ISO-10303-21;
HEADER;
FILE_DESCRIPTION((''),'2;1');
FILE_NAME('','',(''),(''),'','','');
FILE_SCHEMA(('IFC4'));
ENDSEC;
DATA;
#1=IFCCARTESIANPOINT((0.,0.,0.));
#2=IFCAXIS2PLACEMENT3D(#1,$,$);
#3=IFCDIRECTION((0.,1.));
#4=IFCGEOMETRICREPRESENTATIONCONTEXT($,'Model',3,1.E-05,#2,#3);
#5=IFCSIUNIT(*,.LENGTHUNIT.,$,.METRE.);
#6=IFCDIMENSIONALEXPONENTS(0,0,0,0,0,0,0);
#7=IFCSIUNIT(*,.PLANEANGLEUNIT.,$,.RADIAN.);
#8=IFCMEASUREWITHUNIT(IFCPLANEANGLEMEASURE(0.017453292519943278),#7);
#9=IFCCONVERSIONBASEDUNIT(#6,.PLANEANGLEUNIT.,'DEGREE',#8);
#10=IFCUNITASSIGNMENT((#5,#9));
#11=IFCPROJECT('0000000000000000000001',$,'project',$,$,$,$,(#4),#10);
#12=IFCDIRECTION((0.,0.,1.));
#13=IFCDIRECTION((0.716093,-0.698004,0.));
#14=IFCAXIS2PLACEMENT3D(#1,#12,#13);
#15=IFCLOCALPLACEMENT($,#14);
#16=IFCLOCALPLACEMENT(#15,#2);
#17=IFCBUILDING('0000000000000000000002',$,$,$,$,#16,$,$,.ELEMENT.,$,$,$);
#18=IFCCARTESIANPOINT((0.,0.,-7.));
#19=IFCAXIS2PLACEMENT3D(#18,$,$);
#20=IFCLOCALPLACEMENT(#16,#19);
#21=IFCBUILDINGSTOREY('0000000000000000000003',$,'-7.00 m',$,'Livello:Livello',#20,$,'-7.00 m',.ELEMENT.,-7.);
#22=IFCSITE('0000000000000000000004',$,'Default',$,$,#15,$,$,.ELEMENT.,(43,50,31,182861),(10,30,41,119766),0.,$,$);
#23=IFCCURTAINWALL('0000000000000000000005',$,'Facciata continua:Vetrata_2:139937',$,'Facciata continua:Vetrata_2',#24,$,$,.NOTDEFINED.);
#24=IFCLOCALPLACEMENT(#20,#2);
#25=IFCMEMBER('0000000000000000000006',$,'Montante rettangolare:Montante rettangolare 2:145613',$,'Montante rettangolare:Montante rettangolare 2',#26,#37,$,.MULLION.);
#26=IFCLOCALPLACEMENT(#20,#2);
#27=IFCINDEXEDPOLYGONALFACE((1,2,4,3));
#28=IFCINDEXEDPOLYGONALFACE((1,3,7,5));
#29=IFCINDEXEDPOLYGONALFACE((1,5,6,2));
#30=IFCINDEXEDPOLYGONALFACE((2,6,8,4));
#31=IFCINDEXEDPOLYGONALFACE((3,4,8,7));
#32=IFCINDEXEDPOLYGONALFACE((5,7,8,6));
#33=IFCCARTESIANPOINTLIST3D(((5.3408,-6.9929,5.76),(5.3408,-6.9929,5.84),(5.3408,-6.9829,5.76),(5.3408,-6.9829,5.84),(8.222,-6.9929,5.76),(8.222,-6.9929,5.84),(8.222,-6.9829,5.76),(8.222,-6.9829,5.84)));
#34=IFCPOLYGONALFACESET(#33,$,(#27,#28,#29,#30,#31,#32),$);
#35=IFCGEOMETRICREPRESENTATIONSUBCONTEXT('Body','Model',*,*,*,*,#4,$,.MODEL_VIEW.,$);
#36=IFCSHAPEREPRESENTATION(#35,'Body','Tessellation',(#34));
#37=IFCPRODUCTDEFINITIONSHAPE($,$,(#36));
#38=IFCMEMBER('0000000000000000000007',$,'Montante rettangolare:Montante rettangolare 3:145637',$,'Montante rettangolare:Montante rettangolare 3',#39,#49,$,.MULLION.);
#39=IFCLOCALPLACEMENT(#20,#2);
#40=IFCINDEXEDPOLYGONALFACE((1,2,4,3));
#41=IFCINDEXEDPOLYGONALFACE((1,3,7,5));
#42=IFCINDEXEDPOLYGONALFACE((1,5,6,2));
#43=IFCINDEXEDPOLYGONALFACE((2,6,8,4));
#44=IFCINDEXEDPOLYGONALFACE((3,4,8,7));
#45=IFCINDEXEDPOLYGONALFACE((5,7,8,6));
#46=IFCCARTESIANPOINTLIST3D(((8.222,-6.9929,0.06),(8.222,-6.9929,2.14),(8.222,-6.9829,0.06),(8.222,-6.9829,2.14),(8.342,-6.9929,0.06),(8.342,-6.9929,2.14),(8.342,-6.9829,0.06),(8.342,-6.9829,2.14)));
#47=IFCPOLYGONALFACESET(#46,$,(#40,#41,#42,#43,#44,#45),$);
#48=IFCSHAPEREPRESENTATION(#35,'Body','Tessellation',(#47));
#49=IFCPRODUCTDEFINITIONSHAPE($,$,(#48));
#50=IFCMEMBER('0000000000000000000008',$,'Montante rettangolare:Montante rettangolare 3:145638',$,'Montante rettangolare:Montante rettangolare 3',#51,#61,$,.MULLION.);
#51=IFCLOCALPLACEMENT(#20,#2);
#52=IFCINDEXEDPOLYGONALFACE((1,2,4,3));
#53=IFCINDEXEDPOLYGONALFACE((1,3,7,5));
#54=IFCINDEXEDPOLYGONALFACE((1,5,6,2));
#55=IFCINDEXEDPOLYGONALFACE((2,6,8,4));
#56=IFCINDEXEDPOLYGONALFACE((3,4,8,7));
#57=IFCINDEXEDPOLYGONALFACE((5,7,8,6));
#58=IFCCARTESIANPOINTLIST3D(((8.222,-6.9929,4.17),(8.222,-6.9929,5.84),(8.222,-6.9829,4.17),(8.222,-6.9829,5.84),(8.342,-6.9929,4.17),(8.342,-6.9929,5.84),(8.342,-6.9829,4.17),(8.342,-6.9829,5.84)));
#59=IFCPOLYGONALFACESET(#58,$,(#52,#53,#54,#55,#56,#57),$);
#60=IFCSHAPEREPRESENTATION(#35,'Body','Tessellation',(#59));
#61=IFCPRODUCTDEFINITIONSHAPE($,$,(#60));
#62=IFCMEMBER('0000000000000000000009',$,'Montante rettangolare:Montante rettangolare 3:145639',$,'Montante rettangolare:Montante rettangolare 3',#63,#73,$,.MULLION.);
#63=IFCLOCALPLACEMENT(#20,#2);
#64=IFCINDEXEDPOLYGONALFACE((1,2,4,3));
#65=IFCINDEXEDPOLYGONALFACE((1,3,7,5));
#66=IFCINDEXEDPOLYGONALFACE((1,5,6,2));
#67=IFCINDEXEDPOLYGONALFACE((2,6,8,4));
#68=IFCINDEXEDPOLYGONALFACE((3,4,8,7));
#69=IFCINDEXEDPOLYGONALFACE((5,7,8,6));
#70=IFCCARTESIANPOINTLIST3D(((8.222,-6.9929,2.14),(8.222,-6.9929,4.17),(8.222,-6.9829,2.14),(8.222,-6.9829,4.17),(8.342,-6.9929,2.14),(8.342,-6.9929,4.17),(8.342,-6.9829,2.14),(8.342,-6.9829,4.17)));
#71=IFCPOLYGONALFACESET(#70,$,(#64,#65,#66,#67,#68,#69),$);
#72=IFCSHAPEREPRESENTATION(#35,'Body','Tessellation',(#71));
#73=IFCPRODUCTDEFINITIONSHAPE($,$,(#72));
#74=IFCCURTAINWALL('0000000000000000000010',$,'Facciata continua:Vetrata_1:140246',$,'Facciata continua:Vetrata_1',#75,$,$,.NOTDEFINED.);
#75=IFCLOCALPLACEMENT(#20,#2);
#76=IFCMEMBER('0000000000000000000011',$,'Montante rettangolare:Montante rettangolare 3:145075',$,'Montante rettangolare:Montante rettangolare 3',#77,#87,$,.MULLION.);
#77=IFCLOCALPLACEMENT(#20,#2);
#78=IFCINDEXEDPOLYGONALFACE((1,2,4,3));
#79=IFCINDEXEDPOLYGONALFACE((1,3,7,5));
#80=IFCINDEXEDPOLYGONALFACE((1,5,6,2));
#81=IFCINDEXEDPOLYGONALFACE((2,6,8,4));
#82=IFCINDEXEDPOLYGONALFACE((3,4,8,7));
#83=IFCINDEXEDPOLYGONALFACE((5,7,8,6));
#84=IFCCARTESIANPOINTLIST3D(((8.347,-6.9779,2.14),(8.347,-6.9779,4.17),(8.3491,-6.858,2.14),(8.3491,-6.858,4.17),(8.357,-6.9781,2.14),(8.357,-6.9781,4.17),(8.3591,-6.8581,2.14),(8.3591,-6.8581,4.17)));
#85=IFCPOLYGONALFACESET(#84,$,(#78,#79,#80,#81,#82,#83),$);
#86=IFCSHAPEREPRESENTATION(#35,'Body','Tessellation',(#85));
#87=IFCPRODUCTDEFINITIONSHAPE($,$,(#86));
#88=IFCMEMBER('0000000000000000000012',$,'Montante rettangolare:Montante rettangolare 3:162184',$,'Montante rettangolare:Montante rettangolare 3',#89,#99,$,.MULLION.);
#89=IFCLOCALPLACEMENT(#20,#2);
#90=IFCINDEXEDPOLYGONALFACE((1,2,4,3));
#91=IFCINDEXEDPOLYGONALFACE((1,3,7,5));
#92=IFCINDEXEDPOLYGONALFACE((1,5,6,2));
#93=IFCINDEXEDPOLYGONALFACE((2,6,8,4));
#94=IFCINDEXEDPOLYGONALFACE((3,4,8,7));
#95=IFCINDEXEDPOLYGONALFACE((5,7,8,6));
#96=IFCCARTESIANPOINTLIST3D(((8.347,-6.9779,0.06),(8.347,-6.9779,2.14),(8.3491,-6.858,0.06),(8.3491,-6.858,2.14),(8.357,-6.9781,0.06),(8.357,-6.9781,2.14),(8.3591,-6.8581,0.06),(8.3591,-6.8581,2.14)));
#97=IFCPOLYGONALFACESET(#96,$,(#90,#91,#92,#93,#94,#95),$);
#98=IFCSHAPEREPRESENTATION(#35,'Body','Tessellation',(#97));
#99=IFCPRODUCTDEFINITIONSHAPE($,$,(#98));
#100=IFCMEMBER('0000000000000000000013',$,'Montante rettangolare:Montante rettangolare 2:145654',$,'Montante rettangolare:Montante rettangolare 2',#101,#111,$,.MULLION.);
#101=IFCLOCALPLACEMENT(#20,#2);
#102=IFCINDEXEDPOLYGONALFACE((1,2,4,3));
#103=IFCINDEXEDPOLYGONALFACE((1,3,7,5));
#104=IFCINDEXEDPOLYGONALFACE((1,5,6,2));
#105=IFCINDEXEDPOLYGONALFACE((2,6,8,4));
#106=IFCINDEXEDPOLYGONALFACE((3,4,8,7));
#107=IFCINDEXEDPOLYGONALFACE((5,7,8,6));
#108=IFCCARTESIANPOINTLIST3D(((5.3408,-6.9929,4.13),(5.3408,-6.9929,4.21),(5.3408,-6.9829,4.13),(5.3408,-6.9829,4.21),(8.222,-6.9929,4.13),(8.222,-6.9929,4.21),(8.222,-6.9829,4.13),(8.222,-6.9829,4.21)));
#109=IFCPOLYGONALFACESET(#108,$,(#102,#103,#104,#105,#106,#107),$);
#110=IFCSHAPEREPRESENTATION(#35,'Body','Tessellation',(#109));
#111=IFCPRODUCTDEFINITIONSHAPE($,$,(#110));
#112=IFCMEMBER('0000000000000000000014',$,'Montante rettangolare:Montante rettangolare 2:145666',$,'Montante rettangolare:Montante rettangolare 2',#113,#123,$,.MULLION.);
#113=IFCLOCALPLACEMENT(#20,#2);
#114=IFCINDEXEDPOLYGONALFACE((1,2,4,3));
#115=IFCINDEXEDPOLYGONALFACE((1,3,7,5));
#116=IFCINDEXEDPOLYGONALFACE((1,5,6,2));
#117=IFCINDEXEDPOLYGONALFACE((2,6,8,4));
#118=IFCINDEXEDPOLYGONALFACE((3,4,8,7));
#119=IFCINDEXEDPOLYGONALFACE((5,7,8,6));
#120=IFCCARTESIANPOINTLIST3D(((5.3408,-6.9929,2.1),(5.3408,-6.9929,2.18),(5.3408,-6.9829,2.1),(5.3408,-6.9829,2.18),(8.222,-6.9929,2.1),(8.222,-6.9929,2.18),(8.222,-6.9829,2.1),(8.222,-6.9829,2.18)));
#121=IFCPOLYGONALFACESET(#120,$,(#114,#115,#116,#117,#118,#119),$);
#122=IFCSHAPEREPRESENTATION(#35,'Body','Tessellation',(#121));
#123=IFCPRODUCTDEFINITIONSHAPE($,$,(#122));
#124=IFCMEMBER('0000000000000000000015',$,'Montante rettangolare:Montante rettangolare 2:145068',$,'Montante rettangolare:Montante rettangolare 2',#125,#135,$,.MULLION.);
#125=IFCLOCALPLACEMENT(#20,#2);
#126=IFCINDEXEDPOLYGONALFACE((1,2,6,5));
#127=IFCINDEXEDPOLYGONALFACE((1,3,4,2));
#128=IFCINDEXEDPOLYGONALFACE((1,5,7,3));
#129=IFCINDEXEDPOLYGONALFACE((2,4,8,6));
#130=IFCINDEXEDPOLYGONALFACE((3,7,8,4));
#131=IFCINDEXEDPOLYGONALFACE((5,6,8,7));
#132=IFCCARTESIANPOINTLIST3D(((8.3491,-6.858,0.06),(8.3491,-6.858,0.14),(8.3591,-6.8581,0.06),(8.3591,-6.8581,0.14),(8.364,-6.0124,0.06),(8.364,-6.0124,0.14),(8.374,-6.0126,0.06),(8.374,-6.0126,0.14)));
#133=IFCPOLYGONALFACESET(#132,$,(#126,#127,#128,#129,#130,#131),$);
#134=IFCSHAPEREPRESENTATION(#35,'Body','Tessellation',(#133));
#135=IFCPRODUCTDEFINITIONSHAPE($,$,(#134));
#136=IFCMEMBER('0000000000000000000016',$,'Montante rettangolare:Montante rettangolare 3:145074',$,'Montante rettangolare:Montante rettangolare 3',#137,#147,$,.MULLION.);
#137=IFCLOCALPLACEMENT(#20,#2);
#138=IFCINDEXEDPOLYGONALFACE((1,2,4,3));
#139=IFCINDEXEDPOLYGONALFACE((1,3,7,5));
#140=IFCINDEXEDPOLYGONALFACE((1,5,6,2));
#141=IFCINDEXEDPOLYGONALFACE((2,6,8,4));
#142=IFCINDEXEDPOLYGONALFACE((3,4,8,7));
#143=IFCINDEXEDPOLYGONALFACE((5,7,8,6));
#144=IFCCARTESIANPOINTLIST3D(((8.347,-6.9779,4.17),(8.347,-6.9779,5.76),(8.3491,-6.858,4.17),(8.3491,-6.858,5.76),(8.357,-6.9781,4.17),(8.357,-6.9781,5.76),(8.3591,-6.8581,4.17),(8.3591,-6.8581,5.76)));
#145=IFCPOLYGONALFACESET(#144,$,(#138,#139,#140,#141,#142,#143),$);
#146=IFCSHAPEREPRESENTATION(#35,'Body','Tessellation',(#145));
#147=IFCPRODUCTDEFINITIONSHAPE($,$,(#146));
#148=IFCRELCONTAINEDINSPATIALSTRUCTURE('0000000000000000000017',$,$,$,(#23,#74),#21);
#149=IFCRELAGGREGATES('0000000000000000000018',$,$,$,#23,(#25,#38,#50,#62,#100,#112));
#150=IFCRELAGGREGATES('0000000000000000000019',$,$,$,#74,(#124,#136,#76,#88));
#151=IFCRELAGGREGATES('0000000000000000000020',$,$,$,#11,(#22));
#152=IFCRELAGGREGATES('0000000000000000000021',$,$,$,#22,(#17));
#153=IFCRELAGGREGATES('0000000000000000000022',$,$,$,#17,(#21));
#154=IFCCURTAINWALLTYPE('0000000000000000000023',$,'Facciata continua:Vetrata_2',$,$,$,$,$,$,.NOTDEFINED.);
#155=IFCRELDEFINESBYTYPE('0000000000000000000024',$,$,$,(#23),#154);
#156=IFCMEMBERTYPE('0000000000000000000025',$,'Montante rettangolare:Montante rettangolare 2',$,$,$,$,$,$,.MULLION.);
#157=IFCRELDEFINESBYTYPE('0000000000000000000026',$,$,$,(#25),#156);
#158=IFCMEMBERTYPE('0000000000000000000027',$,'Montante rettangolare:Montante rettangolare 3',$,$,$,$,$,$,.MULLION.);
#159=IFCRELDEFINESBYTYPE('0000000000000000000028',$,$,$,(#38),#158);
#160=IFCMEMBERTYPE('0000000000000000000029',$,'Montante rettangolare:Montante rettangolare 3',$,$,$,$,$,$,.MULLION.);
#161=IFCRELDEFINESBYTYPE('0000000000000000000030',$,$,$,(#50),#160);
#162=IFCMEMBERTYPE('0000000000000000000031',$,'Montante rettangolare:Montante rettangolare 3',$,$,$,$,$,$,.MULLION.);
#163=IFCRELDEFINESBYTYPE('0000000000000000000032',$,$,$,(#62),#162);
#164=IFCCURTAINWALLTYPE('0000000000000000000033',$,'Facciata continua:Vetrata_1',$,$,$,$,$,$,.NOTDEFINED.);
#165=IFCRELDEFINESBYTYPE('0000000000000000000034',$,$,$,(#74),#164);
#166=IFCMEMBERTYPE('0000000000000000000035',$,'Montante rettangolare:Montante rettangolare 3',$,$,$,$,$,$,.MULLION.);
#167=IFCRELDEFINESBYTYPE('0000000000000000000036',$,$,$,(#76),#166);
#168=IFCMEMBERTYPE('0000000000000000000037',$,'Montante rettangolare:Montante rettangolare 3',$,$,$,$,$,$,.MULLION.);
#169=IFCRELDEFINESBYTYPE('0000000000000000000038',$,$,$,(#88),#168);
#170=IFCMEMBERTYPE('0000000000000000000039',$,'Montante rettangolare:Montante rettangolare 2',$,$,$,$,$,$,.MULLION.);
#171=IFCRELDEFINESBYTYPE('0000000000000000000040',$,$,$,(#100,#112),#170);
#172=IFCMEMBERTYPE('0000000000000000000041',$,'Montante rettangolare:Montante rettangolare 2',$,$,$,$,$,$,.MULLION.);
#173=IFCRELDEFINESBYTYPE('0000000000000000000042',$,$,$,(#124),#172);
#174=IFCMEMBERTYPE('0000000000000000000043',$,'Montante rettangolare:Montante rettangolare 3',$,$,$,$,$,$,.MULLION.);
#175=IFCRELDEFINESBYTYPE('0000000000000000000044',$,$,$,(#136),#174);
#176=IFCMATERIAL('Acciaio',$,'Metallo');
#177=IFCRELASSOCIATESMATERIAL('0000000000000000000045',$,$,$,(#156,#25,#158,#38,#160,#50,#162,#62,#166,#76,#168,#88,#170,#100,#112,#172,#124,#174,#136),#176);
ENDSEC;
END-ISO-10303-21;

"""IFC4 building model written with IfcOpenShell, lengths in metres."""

from ifc_helpers import new_model, entity, si_unit, converted_unit, direction, frame, origin, place, context, subcontext, project, spatial, indexed_curve, outline, extrude, source, transform, mapped, material, type_object, type_shapes, element, aggregate, save


model = new_model("IFC4")

# Units and contexts
model_context = context("Model", 3, precision=1e-05, world=origin(), true_north=direction((0.0, 1.0)))
body_context = subcontext(model_context, "Body", "Model", "MODEL_VIEW")
ifc_project = project(units=[si_unit("LENGTHUNIT", "METRE"), converted_unit("PLANEANGLEUNIT", "DEGREE", entity("IfcPlaneAngleMeasure", 0.017453292519943278), si_unit("PLANEANGLEUNIT", "RADIAN"), dimensions=[0, 0, 0, 0, 0, 0, 0])], contexts=[model_context])

# Site, building, storey
site_placement = place(None, frame((0.0, 0.0, 0.0), z_axis=(0.0, 0.0, 1.0), x_axis=(0.716093, -0.698004, 0.0)))
site = spatial("IfcSite", under=ifc_project, at=site_placement, Name="Default", CompositionType="ELEMENT", RefLatitude=(43, 50, 31, 182861), RefLongitude=(10, 30, 41, 119766), RefElevation=0.0)
building_placement = place(site_placement, origin())
building = spatial("IfcBuilding", under=site, at=building_placement, CompositionType="ELEMENT")
storey_placement = place(building_placement, frame((0.0, 0.0, -7.0)))
storey = spatial("IfcBuildingStorey", under=building, at=storey_placement, Name="-7.00 m", ObjectType="Livello:Livello", LongName="-7.00 m", CompositionType="ELEMENT", Elevation=-7.0)

# Curtain walls, members
curtain_wall_type_1 = type_object("IfcCurtainWallType", Name="Facciata continua:Vetrata_2", PredefinedType="NOTDEFINED")
curtain_wall_1_placement = place(storey_placement, frame((0.0, 0.0, 7.0)))
curtain_wall_1 = element("IfcCurtainWall", 1, at=curtain_wall_1_placement, inside=storey, type_object=curtain_wall_type_1, Name="Facciata continua:Vetrata_2:139937", ObjectType="Facciata continua:Vetrata_2", PredefinedType="NOTDEFINED")
ifc_material_1 = material(Name="Acciaio", Category="Metallo")
member_type_1 = type_object("IfcMemberType", Name="Montante rettangolare:Montante rettangolare 2", PredefinedType="MULLION", material=ifc_material_1)
shared_shape_1 = source(origin(), body_context, "Body", "SweptSolid", [
    extrude(outline(indexed_curve([(-0.04, -0.005), (0.04, -0.005), (0.04, 0.005), (-0.04, 0.005), (-0.04, -0.005)], self_intersect=False)), frame((-0.04, 0.01, -2.8812), z_axis=(0.0, 0.0, 1.0), x_axis=(-1.0, 0.0, 0.0)), (0.0, 0.0, 1.0), 2.8812),
])
type_shapes(member_type_1, [shared_shape_1])
member_1_placement = place(curtain_wall_1_placement, frame((8.222, -6.9779, -1.16), z_axis=(1.0, 0.0, 0.0), x_axis=(0.0, 0.0, 1.0)))
member_1 = element("IfcMember", 2, at=member_1_placement, type_object=member_type_1, material=ifc_material_1, Name="Montante rettangolare:Montante rettangolare 2:145613", ObjectType="Montante rettangolare:Montante rettangolare 2", PredefinedType="MULLION", context=body_context, shape_type="MappedRepresentation", body=[
    mapped(shared_shape_1, transform((0.0, 0.0, 0.0), scale=1.0)),
])
member_type_2 = type_object("IfcMemberType", Name="Montante rettangolare:Montante rettangolare 3", PredefinedType="MULLION", material=ifc_material_1)
shared_shape_2 = source(origin(), body_context, "Body", "SweptSolid", [
    extrude(outline(indexed_curve([(-0.06, -0.005), (0.06, -0.005), (0.06, 0.005), (-0.06, 0.005), (-0.06, -0.005)], self_intersect=False)), frame((-0.06, 0.01, -2.08), z_axis=(0.0, 0.0, 1.0), x_axis=(-1.0, 0.0, 0.0)), (0.0, 0.0, 1.0), 2.08),
])
type_shapes(member_type_2, [shared_shape_2])
member_2_placement = place(curtain_wall_1_placement, frame((8.342, -6.9779, -6.94), z_axis=(0.0, 0.0, -1.0), x_axis=(1.0, 0.0, 0.0)))
member_2 = element("IfcMember", 3, at=member_2_placement, type_object=member_type_2, material=ifc_material_1, Name="Montante rettangolare:Montante rettangolare 3:145637", ObjectType="Montante rettangolare:Montante rettangolare 3", PredefinedType="MULLION", context=body_context, shape_type="MappedRepresentation", body=[
    mapped(shared_shape_2, transform((0.0, 0.0, 0.0), scale=1.0)),
])
member_type_3 = type_object("IfcMemberType", Name="Montante rettangolare:Montante rettangolare 3", PredefinedType="MULLION", material=ifc_material_1)
shared_shape_3 = source(origin(), body_context, "Body", "SweptSolid", [
    extrude(outline(indexed_curve([(-0.06, -0.005), (0.06, -0.005), (0.06, 0.005), (-0.06, 0.005), (-0.06, -0.005)], self_intersect=False)), frame((-0.06, 0.01, -1.67), z_axis=(0.0, 0.0, 1.0), x_axis=(-1.0, 0.0, 0.0)), (0.0, 0.0, 1.0), 1.67),
])
type_shapes(member_type_3, [shared_shape_3])
member_3_placement = place(curtain_wall_1_placement, frame((8.342, -6.9779, -2.83), z_axis=(0.0, 0.0, -1.0), x_axis=(1.0, 0.0, 0.0)))
member_3 = element("IfcMember", 4, at=member_3_placement, type_object=member_type_3, material=ifc_material_1, Name="Montante rettangolare:Montante rettangolare 3:145638", ObjectType="Montante rettangolare:Montante rettangolare 3", PredefinedType="MULLION", context=body_context, shape_type="MappedRepresentation", body=[
    mapped(shared_shape_3, transform((0.0, 0.0, 0.0), scale=1.0)),
])
member_type_4 = type_object("IfcMemberType", Name="Montante rettangolare:Montante rettangolare 3", PredefinedType="MULLION", material=ifc_material_1)
shared_shape_4 = source(origin(), body_context, "Body", "SweptSolid", [
    extrude(outline(indexed_curve([(-0.06, -0.005), (0.06, -0.005), (0.06, 0.005), (-0.06, 0.005), (-0.06, -0.005)], self_intersect=False)), frame((-0.06, 0.01, -2.03), z_axis=(0.0, 0.0, 1.0), x_axis=(-1.0, 0.0, 0.0)), (0.0, 0.0, 1.0), 2.03),
])
type_shapes(member_type_4, [shared_shape_4])
member_4_placement = place(curtain_wall_1_placement, frame((8.342, -6.9779, -4.86), z_axis=(0.0, 0.0, -1.0), x_axis=(1.0, 0.0, 0.0)))
member_4 = element("IfcMember", 5, at=member_4_placement, type_object=member_type_4, material=ifc_material_1, Name="Montante rettangolare:Montante rettangolare 3:145639", ObjectType="Montante rettangolare:Montante rettangolare 3", PredefinedType="MULLION", context=body_context, shape_type="MappedRepresentation", body=[
    mapped(shared_shape_4, transform((0.0, 0.0, 0.0), scale=1.0)),
])
curtain_wall_type_2 = type_object("IfcCurtainWallType", Name="Facciata continua:Vetrata_1", PredefinedType="NOTDEFINED")
curtain_wall_2_placement = place(storey_placement, frame((0.0, 0.0, 7.0)))
curtain_wall_2 = element("IfcCurtainWall", 6, at=curtain_wall_2_placement, inside=storey, type_object=curtain_wall_type_2, Name="Facciata continua:Vetrata_1:140246", ObjectType="Facciata continua:Vetrata_1", PredefinedType="NOTDEFINED")
member_type_5 = type_object("IfcMemberType", Name="Montante rettangolare:Montante rettangolare 3", PredefinedType="MULLION", material=ifc_material_1)
shared_shape_5 = source(origin(), body_context, "Body", "SweptSolid", [
    extrude(outline(indexed_curve([(-0.06, -0.005), (0.06, -0.005), (0.06, 0.005), (-0.06, 0.005), (-0.06, -0.005)], self_intersect=False)), frame((-0.06, 0.01, -2.03), z_axis=(0.0, 0.0, 1.0), x_axis=(-1.0, 0.0, 0.0)), (0.0, 0.0, 1.0), 2.03),
])
type_shapes(member_type_5, [shared_shape_5])
member_5_placement = place(curtain_wall_2_placement, frame((8.342, -6.9779, -2.83), z_axis=(0.0, 0.0, 1.0), x_axis=(-0.017636, -0.999844, 0.0)))
member_5 = element("IfcMember", 7, at=member_5_placement, type_object=member_type_5, material=ifc_material_1, Name="Montante rettangolare:Montante rettangolare 3:145075", ObjectType="Montante rettangolare:Montante rettangolare 3", PredefinedType="MULLION", context=body_context, shape_type="MappedRepresentation", body=[
    mapped(shared_shape_5, transform((0.0, 0.0, 0.0), scale=1.0)),
])
member_type_6 = type_object("IfcMemberType", Name="Montante rettangolare:Montante rettangolare 3", PredefinedType="MULLION", material=ifc_material_1)
shared_shape_6 = source(origin(), body_context, "Body", "SweptSolid", [
    extrude(outline(indexed_curve([(-0.06, -0.005), (0.06, -0.005), (0.06, 0.005), (-0.06, 0.005), (-0.06, -0.005)], self_intersect=False)), frame((-0.06, 0.01, -2.08), z_axis=(0.0, 0.0, 1.0), x_axis=(-1.0, 0.0, 0.0)), (0.0, 0.0, 1.0), 2.08),
])
type_shapes(member_type_6, [shared_shape_6])
member_6_placement = place(curtain_wall_2_placement, frame((8.342, -6.9779, -4.86), z_axis=(0.0, 0.0, 1.0), x_axis=(-0.017636, -0.999844, 0.0)))
member_6 = element("IfcMember", 8, at=member_6_placement, type_object=member_type_6, material=ifc_material_1, Name="Montante rettangolare:Montante rettangolare 3:162184", ObjectType="Montante rettangolare:Montante rettangolare 3", PredefinedType="MULLION", context=body_context, shape_type="MappedRepresentation", body=[
    mapped(shared_shape_6, transform((0.0, 0.0, 0.0), scale=1.0)),
])

# Members
member_type_7 = type_object("IfcMemberType", Name="Montante rettangolare:Montante rettangolare 2", PredefinedType="MULLION", material=ifc_material_1)
shared_shape_7 = source(origin(), body_context, "Body", "SweptSolid", [
    extrude(outline(indexed_curve([(-0.04, -0.005), (0.04, -0.005), (0.04, 0.005), (-0.04, 0.005), (-0.04, -0.005)], self_intersect=False)), frame((0.0, 0.01, -2.8812), z_axis=(0.0, 0.0, 1.0), x_axis=(-1.0, 0.0, 0.0)), (0.0, 0.0, 1.0), 2.8812),
])
type_shapes(member_type_7, [shared_shape_7])
member_7_placement = place(curtain_wall_1_placement, frame((8.222, -6.9779, -2.83), z_axis=(1.0, 0.0, 0.0), x_axis=(0.0, 0.0, 1.0)))
member_7 = element("IfcMember", 9, at=member_7_placement, type_object=member_type_7, material=ifc_material_1, Name="Montante rettangolare:Montante rettangolare 2:145654", ObjectType="Montante rettangolare:Montante rettangolare 2", PredefinedType="MULLION", context=body_context, shape_type="MappedRepresentation", body=[
    mapped(shared_shape_7, transform((0.0, 0.0, 0.0), scale=1.0)),
])
member_8_placement = place(curtain_wall_1_placement, frame((8.222, -6.9779, -4.86), z_axis=(1.0, 0.0, 0.0), x_axis=(0.0, 0.0, 1.0)))
member_8 = element("IfcMember", 10, at=member_8_placement, type_object=member_type_7, material=ifc_material_1, Name="Montante rettangolare:Montante rettangolare 2:145666", ObjectType="Montante rettangolare:Montante rettangolare 2", PredefinedType="MULLION", context=body_context, shape_type="MappedRepresentation", body=[
    mapped(shared_shape_7, transform((0.0, 0.0, 0.0), scale=1.0)),
])
member_type_8 = type_object("IfcMemberType", Name="Montante rettangolare:Montante rettangolare 2", PredefinedType="MULLION", material=ifc_material_1)
shared_shape_8 = source(origin(), body_context, "Body", "SweptSolid", [
    extrude(outline(indexed_curve([(-0.04, -0.005), (0.04, -0.005), (0.04, 0.005), (-0.04, 0.005), (-0.04, -0.005)], self_intersect=False)), frame((-0.04, 0.01, -0.8457), z_axis=(0.0, 0.0, 1.0), x_axis=(-1.0, 0.0, 0.0)), (0.0, 0.0, 1.0), 0.8457),
])
type_shapes(member_type_8, [shared_shape_8])
member_9_placement = place(curtain_wall_2_placement, frame((8.3441, -6.8579, -6.94), z_axis=(-0.017636, -0.999844, 0.0), x_axis=(0.0, 0.0, -1.0)))
member_9 = element("IfcMember", 11, at=member_9_placement, type_object=member_type_8, material=ifc_material_1, Name="Montante rettangolare:Montante rettangolare 2:145068", ObjectType="Montante rettangolare:Montante rettangolare 2", PredefinedType="MULLION", context=body_context, shape_type="MappedRepresentation", body=[
    mapped(shared_shape_8, transform((0.0, 0.0, 0.0), scale=1.0)),
])
member_type_9 = type_object("IfcMemberType", Name="Montante rettangolare:Montante rettangolare 3", PredefinedType="MULLION", material=ifc_material_1)
shared_shape_9 = source(origin(), body_context, "Body", "SweptSolid", [
    extrude(outline(indexed_curve([(-0.06, -0.005), (0.06, -0.005), (0.06, 0.005), (-0.06, 0.005), (-0.06, -0.005)], self_intersect=False)), frame((-0.06, 0.01, -1.59), z_axis=(0.0, 0.0, 1.0), x_axis=(-1.0, 0.0, 0.0)), (0.0, 0.0, 1.0), 1.59),
])
type_shapes(member_type_9, [shared_shape_9])
member_10_placement = place(curtain_wall_2_placement, frame((8.342, -6.9779, -1.24), z_axis=(0.0, 0.0, 1.0), x_axis=(-0.017636, -0.999844, 0.0)))
member_10 = element("IfcMember", 12, at=member_10_placement, type_object=member_type_9, material=ifc_material_1, Name="Montante rettangolare:Montante rettangolare 3:145074", ObjectType="Montante rettangolare:Montante rettangolare 3", PredefinedType="MULLION", context=body_context, shape_type="MappedRepresentation", body=[
    mapped(shared_shape_9, transform((0.0, 0.0, 0.0), scale=1.0)),
])

aggregate(curtain_wall_1, [member_1, member_2, member_3, member_4, member_7, member_8])

aggregate(curtain_wall_2, [member_9, member_10, member_5, member_6])

save(model, "model.ifc")
